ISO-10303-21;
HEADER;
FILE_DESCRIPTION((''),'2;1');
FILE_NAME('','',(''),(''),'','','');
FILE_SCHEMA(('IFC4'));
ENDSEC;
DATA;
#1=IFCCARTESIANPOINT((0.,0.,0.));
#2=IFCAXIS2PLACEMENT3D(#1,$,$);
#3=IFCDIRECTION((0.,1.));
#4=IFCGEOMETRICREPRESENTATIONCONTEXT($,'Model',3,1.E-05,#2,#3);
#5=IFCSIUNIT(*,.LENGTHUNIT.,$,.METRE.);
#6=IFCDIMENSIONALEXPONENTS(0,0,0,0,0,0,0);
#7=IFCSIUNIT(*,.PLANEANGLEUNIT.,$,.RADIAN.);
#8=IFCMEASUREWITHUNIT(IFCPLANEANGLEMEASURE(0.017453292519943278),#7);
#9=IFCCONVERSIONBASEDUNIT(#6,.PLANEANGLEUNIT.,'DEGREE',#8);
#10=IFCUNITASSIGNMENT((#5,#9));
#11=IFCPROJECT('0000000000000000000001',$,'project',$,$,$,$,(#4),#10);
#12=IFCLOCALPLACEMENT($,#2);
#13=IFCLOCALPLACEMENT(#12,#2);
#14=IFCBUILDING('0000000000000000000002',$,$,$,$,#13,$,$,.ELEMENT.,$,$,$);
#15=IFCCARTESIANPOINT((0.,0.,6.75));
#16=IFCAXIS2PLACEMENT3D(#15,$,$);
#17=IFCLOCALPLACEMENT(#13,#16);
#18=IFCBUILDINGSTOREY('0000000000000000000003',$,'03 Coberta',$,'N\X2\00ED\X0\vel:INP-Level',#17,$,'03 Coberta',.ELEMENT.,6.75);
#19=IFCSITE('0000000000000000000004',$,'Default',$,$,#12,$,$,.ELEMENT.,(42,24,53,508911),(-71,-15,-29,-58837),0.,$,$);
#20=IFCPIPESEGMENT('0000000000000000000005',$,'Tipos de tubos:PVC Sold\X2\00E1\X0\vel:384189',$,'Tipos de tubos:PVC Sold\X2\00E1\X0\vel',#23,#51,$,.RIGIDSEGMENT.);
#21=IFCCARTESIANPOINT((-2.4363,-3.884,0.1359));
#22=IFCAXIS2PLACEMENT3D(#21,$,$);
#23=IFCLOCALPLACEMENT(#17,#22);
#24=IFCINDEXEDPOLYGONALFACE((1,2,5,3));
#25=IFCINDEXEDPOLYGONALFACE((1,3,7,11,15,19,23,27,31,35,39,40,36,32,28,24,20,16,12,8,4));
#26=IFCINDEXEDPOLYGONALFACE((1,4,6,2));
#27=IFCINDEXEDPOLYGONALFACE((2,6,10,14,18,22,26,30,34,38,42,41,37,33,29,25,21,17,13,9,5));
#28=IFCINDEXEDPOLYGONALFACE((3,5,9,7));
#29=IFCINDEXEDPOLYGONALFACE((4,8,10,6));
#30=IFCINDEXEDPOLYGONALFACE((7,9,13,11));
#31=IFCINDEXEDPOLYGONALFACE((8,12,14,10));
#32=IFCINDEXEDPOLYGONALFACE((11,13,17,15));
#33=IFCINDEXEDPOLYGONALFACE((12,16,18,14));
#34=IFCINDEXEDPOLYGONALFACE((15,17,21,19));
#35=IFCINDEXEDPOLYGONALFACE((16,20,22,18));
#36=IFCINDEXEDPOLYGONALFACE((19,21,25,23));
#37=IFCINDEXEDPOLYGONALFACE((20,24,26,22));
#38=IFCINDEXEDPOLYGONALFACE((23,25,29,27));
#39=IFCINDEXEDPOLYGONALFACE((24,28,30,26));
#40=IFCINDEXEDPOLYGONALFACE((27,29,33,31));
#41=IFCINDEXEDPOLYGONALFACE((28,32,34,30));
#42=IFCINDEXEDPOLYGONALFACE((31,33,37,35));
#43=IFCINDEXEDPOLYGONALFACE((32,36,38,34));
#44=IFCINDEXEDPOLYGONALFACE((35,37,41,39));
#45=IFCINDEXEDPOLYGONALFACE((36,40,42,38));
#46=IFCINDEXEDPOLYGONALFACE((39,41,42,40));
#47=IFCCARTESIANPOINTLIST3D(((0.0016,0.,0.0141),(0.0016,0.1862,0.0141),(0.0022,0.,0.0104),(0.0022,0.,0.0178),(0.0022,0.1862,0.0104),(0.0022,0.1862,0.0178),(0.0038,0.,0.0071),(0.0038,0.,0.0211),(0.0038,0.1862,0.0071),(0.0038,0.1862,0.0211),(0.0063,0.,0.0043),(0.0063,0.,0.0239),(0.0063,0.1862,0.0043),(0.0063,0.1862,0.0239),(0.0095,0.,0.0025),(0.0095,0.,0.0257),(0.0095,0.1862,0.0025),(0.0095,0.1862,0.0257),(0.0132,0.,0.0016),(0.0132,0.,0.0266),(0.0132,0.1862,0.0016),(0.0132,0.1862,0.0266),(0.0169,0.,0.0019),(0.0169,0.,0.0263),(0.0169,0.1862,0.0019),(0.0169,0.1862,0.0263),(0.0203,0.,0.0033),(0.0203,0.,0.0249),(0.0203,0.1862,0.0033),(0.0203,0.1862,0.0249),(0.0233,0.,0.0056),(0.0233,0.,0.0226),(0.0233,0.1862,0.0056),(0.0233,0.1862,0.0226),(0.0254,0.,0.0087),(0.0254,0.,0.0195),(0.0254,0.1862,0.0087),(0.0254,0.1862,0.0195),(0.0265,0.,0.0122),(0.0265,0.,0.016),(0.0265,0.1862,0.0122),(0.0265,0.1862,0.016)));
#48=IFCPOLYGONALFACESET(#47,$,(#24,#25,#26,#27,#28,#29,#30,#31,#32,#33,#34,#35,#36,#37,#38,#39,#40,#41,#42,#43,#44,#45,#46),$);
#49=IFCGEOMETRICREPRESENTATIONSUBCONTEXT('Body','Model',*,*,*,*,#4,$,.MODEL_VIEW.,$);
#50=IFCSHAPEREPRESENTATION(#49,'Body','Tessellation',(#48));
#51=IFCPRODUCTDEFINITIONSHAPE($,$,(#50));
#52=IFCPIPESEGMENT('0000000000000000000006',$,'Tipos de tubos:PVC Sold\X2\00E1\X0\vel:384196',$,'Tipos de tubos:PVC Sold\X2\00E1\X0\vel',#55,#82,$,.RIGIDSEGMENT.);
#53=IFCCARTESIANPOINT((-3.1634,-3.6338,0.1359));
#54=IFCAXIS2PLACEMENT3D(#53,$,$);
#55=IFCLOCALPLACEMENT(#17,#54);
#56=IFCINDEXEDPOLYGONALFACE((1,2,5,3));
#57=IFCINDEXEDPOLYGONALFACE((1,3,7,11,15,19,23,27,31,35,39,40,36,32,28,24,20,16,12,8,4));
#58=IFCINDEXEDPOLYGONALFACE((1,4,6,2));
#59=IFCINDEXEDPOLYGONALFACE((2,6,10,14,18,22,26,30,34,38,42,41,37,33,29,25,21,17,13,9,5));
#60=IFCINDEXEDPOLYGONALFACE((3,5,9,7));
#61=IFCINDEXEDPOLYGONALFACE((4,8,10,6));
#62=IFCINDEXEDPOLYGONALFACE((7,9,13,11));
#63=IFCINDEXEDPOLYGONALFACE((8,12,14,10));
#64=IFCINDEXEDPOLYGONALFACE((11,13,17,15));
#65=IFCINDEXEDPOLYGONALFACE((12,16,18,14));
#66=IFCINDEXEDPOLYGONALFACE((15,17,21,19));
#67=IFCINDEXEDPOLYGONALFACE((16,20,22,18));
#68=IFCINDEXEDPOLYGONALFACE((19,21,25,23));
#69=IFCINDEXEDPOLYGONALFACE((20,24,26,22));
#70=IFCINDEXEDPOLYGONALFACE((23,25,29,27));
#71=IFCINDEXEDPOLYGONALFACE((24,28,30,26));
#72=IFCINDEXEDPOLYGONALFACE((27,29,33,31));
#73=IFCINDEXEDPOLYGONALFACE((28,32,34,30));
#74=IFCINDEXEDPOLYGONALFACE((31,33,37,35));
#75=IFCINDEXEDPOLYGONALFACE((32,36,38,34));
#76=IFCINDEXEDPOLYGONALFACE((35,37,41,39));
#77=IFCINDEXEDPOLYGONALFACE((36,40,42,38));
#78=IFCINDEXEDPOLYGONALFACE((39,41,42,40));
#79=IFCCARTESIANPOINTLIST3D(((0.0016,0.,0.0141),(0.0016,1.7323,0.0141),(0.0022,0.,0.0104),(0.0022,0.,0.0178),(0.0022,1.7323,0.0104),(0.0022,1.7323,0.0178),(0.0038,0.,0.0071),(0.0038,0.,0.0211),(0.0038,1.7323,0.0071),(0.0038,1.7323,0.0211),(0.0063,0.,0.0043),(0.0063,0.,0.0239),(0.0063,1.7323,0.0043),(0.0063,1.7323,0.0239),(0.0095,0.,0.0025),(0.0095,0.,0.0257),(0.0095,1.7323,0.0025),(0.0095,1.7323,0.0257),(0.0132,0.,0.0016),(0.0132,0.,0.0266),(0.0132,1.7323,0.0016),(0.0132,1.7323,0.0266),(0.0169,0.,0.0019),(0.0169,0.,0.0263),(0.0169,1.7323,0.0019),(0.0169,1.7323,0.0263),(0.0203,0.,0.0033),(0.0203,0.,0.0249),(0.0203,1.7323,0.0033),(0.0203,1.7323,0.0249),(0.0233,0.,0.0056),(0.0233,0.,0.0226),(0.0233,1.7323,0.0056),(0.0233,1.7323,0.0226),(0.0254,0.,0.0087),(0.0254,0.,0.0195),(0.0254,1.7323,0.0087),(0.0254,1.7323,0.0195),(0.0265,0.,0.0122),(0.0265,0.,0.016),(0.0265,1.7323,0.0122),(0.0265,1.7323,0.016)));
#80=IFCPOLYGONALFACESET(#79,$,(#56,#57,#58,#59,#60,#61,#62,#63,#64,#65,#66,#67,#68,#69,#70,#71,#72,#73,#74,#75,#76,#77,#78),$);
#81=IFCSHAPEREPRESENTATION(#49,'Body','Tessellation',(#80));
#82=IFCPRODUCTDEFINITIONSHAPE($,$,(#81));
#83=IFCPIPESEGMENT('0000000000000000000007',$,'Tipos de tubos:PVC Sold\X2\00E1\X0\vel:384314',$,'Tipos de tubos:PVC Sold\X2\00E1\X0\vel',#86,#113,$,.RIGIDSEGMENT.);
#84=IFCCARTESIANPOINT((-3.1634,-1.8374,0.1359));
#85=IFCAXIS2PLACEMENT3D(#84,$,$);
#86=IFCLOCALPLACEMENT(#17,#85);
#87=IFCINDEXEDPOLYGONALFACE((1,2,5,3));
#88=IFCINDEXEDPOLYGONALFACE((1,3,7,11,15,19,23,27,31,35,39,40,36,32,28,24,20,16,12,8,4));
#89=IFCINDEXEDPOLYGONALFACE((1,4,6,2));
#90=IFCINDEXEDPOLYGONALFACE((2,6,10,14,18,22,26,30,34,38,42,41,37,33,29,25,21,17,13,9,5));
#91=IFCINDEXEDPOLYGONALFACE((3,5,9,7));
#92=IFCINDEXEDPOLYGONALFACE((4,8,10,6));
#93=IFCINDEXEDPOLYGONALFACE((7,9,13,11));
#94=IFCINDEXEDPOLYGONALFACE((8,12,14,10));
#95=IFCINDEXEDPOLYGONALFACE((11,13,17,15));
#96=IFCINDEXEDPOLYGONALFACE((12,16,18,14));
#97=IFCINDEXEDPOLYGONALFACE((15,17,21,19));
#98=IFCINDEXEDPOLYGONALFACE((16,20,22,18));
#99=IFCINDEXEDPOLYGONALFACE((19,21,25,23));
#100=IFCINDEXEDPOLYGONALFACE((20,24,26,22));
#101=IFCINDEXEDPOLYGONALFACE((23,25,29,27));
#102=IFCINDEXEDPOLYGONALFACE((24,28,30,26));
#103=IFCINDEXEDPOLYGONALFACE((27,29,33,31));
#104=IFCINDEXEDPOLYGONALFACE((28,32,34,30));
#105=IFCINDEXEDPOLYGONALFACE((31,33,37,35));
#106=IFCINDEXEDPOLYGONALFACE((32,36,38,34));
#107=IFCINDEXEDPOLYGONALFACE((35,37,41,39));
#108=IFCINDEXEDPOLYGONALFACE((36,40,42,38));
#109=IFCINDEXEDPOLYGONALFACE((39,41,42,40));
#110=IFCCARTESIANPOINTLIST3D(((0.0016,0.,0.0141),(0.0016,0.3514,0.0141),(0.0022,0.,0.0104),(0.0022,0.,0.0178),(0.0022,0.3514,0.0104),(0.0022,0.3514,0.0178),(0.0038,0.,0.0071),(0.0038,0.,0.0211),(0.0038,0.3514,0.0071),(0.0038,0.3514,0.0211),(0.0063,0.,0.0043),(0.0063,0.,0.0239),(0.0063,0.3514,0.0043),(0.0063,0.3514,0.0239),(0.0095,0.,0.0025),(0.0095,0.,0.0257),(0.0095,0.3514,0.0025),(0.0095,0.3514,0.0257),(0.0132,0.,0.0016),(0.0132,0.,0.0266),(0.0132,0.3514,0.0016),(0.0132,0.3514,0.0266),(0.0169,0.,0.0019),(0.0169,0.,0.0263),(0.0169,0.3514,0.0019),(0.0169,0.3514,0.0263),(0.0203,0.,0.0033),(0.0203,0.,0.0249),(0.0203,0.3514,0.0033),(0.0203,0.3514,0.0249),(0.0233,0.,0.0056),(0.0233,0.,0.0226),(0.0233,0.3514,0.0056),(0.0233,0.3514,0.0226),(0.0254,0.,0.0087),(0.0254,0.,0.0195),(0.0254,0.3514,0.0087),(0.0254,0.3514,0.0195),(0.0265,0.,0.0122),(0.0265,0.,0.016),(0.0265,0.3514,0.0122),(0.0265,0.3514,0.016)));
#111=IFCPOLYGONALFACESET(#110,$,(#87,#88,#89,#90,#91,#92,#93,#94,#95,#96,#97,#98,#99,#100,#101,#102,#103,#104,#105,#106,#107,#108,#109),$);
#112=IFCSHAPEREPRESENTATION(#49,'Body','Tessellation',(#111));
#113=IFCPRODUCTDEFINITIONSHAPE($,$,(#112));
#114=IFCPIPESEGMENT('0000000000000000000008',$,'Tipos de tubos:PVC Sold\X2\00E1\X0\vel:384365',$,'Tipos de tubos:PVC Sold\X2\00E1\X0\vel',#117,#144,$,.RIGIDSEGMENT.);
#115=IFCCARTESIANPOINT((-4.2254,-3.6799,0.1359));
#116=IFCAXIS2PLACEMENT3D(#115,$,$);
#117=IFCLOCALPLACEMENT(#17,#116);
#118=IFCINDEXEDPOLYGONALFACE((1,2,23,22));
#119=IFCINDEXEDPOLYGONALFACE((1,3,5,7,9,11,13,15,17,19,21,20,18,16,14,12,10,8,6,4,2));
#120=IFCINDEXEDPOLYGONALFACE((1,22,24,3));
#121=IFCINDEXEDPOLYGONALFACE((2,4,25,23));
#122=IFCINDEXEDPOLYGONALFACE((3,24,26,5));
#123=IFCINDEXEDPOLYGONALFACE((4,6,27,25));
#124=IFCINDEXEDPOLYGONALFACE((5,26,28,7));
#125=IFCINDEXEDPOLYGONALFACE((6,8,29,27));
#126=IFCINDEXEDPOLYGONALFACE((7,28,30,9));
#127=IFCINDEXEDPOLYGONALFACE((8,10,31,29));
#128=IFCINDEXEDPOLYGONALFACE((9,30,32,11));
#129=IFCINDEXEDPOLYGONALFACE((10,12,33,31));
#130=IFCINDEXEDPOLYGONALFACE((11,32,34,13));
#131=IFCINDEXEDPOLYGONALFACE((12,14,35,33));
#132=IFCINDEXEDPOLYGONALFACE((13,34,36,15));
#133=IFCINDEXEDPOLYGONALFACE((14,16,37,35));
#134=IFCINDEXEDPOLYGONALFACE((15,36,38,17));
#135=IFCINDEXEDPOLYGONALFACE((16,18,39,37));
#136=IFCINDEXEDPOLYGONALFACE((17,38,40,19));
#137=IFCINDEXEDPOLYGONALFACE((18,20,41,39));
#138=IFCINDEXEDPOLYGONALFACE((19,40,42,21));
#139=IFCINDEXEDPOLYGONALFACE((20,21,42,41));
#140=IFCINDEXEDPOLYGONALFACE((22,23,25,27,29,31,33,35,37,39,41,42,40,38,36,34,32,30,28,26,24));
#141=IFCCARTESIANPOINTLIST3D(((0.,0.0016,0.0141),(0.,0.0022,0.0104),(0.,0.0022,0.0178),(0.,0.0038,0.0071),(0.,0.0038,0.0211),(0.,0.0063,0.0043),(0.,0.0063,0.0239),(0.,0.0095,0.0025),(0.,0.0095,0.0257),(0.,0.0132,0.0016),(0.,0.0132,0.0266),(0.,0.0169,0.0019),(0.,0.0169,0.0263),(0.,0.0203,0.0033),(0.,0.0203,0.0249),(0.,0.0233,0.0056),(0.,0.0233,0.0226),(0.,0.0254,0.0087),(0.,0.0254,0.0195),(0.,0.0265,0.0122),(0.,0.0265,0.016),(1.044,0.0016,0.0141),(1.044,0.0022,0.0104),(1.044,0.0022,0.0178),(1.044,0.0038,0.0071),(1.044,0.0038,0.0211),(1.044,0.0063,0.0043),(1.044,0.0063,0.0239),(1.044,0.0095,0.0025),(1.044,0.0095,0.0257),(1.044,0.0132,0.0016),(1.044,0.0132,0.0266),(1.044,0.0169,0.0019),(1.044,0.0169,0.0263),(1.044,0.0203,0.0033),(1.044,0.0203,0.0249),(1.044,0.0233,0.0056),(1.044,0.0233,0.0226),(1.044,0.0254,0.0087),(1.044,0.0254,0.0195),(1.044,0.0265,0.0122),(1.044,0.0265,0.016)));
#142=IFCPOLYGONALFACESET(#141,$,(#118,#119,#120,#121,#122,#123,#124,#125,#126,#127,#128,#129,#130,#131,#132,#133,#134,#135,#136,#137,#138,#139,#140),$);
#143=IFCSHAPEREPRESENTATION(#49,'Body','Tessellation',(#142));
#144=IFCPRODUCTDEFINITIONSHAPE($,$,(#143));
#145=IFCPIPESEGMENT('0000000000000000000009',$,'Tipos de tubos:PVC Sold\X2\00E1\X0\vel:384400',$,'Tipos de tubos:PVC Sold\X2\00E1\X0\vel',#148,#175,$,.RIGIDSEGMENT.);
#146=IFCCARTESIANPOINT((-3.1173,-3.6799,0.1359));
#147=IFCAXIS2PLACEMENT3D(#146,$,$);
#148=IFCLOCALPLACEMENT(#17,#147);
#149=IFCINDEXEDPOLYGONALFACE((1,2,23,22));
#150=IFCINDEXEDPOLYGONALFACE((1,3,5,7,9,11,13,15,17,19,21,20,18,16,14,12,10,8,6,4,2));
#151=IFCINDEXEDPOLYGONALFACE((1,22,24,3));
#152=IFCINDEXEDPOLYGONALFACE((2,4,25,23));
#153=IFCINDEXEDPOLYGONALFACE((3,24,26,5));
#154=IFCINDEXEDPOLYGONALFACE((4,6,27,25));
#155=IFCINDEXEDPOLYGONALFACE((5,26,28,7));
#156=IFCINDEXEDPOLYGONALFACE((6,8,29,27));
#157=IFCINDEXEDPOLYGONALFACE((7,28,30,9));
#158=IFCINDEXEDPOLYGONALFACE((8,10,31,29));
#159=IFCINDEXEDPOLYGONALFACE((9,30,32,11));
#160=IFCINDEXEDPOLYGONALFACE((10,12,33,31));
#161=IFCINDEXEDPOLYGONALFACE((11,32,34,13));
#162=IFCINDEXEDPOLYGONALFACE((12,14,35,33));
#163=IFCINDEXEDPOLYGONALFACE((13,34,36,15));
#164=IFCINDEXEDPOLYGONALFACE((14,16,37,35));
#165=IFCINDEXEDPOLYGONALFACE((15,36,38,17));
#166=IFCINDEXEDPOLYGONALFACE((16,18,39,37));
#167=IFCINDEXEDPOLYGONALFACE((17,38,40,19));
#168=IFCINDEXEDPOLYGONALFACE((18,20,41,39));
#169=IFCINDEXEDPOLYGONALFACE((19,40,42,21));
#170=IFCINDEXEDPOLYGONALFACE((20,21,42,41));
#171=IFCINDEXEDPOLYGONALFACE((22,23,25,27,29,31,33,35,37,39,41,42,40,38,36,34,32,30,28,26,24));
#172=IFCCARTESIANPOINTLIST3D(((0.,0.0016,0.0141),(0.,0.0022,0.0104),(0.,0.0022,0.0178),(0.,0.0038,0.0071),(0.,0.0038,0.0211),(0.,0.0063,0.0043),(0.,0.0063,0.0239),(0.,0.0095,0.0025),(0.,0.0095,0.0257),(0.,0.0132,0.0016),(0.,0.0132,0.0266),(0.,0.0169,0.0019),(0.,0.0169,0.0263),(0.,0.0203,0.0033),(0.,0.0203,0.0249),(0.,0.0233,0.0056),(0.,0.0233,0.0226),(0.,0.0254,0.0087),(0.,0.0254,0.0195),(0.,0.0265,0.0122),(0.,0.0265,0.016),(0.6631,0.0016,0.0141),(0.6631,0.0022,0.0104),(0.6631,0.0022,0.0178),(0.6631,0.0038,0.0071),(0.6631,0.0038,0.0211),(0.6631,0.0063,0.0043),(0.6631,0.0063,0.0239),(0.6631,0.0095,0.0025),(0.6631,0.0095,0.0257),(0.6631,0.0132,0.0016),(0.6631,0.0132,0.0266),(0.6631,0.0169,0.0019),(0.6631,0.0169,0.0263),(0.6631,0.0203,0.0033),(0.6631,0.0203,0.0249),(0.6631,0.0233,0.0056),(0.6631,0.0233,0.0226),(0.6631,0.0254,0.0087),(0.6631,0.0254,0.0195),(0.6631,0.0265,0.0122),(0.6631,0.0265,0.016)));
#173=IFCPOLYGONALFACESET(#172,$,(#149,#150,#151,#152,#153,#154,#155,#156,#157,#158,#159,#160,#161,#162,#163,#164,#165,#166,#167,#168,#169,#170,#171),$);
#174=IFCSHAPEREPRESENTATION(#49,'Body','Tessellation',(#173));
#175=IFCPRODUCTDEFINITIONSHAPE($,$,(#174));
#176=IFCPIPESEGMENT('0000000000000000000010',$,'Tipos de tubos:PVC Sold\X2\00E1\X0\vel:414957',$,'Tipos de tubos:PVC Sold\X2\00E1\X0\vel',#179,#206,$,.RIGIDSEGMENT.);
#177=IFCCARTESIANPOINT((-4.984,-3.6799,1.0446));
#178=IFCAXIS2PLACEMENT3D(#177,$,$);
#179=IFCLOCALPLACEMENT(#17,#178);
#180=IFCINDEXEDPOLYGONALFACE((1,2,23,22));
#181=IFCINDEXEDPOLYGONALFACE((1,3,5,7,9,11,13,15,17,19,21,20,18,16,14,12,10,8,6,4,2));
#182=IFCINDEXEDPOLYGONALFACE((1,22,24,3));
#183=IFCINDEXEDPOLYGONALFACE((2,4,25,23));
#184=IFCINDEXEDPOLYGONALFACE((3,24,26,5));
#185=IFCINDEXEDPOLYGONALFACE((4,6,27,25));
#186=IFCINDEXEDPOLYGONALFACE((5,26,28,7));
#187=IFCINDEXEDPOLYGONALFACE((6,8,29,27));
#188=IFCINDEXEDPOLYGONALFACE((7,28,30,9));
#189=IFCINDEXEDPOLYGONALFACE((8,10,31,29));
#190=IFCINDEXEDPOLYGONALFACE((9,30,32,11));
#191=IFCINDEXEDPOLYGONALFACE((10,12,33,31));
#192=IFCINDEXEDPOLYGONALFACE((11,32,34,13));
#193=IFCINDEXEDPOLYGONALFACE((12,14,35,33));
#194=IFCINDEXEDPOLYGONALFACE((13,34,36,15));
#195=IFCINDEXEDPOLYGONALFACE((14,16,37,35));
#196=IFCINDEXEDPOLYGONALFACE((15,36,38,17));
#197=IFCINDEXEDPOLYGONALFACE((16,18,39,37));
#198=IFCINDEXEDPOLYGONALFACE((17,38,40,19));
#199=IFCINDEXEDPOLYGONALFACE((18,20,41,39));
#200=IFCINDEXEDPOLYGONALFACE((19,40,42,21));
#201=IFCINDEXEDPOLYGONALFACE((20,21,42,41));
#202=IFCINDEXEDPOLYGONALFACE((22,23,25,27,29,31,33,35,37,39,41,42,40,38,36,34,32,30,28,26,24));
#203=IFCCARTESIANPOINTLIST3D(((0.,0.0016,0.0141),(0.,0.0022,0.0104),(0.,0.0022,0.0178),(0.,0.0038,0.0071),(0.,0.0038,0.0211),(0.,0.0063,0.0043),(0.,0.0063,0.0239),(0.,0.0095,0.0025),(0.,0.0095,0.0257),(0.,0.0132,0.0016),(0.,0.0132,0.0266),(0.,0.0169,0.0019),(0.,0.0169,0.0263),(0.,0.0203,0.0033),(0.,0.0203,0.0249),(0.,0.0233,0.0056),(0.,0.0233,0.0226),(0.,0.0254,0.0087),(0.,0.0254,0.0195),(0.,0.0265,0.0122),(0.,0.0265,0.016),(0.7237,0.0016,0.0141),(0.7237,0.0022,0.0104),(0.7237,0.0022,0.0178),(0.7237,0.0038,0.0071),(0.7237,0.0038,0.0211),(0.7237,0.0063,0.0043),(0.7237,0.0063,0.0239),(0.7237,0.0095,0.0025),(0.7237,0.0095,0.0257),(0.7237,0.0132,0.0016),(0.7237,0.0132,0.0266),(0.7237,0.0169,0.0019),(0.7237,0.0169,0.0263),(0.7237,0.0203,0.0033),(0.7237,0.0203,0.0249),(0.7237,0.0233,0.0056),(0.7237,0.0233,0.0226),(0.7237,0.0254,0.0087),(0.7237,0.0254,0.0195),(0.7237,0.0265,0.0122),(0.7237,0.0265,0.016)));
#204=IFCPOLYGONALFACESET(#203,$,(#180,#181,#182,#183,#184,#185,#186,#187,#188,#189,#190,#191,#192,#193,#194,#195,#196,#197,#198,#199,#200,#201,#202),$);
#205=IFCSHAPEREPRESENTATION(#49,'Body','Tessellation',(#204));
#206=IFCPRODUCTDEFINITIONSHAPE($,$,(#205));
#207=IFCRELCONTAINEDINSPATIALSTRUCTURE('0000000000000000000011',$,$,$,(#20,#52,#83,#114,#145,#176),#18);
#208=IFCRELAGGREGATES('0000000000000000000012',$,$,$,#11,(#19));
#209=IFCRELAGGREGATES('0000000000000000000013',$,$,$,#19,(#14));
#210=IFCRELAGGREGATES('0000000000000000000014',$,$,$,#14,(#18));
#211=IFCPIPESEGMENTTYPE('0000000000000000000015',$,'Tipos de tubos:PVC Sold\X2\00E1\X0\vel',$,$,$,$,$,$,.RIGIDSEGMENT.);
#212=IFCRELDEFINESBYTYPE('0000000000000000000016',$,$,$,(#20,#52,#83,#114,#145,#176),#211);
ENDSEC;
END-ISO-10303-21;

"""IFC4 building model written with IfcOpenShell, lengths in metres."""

from ifc_helpers import new_model, entity, si_unit, converted_unit, direction, frame, frame_2d, origin, origin_2d_with_axis, place, context, subcontext, project, spatial, circle, extrude, type_object, element, save


model = new_model("IFC4")

# Units and contexts
model_context = context("Model", 3, precision=1e-05, world=origin(), true_north=direction((0.0, 1.0)))
body_context = subcontext(model_context, "Body", "Model", "MODEL_VIEW")
ifc_project = project(units=[si_unit("LENGTHUNIT", "METRE"), converted_unit("PLANEANGLEUNIT", "DEGREE", entity("IfcPlaneAngleMeasure", 0.017453292519943278), si_unit("PLANEANGLEUNIT", "RADIAN"), dimensions=[0, 0, 0, 0, 0, 0, 0])], contexts=[model_context])

# Site, building, storey
site_placement = place(None, origin())
site = spatial("IfcSite", under=ifc_project, at=site_placement, Name="Default", CompositionType="ELEMENT", RefLatitude=(42, 24, 53, 508911), RefLongitude=(-71, -15, -29, -58837), RefElevation=0.0)
building_placement = place(site_placement, origin())
building = spatial("IfcBuilding", under=site, at=building_placement, CompositionType="ELEMENT")
storey_placement = place(building_placement, frame((0.0, 0.0, 6.75)))
storey = spatial("IfcBuildingStorey", under=building, at=storey_placement, Name="03 Coberta", ObjectType="Nível:INP-Level", LongName="03 Coberta", CompositionType="ELEMENT", Elevation=6.75)

# Pipe segments
pipe_segment_type = type_object("IfcPipeSegmentType", Name="Tipos de tubos:PVC Soldável", PredefinedType="RIGIDSEGMENT")
pipe_segment_1_placement = place(storey_placement, frame((-2.4363, -3.884, 0.1359)))
element("IfcPipeSegment", 1, at=pipe_segment_1_placement, inside=storey, type_object=pipe_segment_type, Name="Tipos de tubos:PVC Soldável:384189", ObjectType="Tipos de tubos:PVC Soldável", PredefinedType="RIGIDSEGMENT", context=body_context, shape_type="SweptSolid", body=[
    extrude(circle(Radius=0.0125, at=frame_2d((0.0, 0.0), x_axis=(1.0, 0.0))), frame((0.0141, 0.0, 0.0141), z_axis=(0.0, 1.0, 0.0), x_axis=(-1.0, 0.0, 0.0)), (0.0, 0.0, 1.0), 0.1862),
])
pipe_segment_2_placement = place(storey_placement, frame((-3.1634, -3.6338, 0.1359)))
element("IfcPipeSegment", 2, at=pipe_segment_2_placement, inside=storey, type_object=pipe_segment_type, Name="Tipos de tubos:PVC Soldável:384196", ObjectType="Tipos de tubos:PVC Soldável", PredefinedType="RIGIDSEGMENT", context=body_context, shape_type="SweptSolid", body=[
    extrude(circle(Radius=0.0125, at=frame_2d((0.0, 0.0), x_axis=(1.0, 0.0))), frame((0.0141, 0.0, 0.0141), z_axis=(0.0, 1.0, 0.0), x_axis=(-1.0, 0.0, 0.0)), (0.0, 0.0, 1.0), 1.7323),
])
pipe_segment_3_placement = place(storey_placement, frame((-3.1634, -1.8374, 0.1359)))
element("IfcPipeSegment", 3, at=pipe_segment_3_placement, inside=storey, type_object=pipe_segment_type, Name="Tipos de tubos:PVC Soldável:384314", ObjectType="Tipos de tubos:PVC Soldável", PredefinedType="RIGIDSEGMENT", context=body_context, shape_type="SweptSolid", body=[
    extrude(circle(Radius=0.0125, at=frame_2d((0.0, 0.0), x_axis=(1.0, 0.0))), frame((0.0141, 0.0, 0.0141), z_axis=(0.0, 1.0, 0.0), x_axis=(-1.0, 0.0, 0.0)), (0.0, 0.0, 1.0), 0.3514),
])
pipe_segment_4_placement = place(storey_placement, frame((-4.2254, -3.6799, 0.1359)))
element("IfcPipeSegment", 4, at=pipe_segment_4_placement, inside=storey, type_object=pipe_segment_type, Name="Tipos de tubos:PVC Soldável:384365", ObjectType="Tipos de tubos:PVC Soldável", PredefinedType="RIGIDSEGMENT", context=body_context, shape_type="SweptSolid", body=[
    extrude(circle(Radius=0.0125, at=frame_2d((0.0, 0.0), x_axis=(1.0, 0.0))), frame((0.0, 0.0141, 0.0141), z_axis=(1.0, 0.0, 0.0), x_axis=(0.0, -1.0, 0.0)), (0.0, 0.0, 1.0), 1.044),
])
pipe_segment_5_placement = place(storey_placement, frame((-3.1173, -3.6799, 0.1359)))
element("IfcPipeSegment", 5, at=pipe_segment_5_placement, inside=storey, type_object=pipe_segment_type, Name="Tipos de tubos:PVC Soldável:384400", ObjectType="Tipos de tubos:PVC Soldável", PredefinedType="RIGIDSEGMENT", context=body_context, shape_type="SweptSolid", body=[
    extrude(circle(Radius=0.0125, at=origin_2d_with_axis()), frame((0.0, 0.0141, 0.0141), z_axis=(1.0, 0.0, 0.0), x_axis=(0.0, -1.0, 0.0)), (0.0, 0.0, 1.0), 0.6631),
])
pipe_segment_6_placement = place(storey_placement, frame((-4.984, -3.6799, 1.0446)))
element("IfcPipeSegment", 6, at=pipe_segment_6_placement, inside=storey, type_object=pipe_segment_type, Name="Tipos de tubos:PVC Soldável:414957", ObjectType="Tipos de tubos:PVC Soldável", PredefinedType="RIGIDSEGMENT", context=body_context, shape_type="SweptSolid", body=[
    extrude(circle(Radius=0.0125, at=origin_2d_with_axis()), frame((0.0, 0.0141, 0.0141), z_axis=(1.0, 0.0, 0.0), x_axis=(0.0, -1.0, 0.0)), (0.0, 0.0, 1.0), 0.7237),
])

save(model, "model.ifc")
